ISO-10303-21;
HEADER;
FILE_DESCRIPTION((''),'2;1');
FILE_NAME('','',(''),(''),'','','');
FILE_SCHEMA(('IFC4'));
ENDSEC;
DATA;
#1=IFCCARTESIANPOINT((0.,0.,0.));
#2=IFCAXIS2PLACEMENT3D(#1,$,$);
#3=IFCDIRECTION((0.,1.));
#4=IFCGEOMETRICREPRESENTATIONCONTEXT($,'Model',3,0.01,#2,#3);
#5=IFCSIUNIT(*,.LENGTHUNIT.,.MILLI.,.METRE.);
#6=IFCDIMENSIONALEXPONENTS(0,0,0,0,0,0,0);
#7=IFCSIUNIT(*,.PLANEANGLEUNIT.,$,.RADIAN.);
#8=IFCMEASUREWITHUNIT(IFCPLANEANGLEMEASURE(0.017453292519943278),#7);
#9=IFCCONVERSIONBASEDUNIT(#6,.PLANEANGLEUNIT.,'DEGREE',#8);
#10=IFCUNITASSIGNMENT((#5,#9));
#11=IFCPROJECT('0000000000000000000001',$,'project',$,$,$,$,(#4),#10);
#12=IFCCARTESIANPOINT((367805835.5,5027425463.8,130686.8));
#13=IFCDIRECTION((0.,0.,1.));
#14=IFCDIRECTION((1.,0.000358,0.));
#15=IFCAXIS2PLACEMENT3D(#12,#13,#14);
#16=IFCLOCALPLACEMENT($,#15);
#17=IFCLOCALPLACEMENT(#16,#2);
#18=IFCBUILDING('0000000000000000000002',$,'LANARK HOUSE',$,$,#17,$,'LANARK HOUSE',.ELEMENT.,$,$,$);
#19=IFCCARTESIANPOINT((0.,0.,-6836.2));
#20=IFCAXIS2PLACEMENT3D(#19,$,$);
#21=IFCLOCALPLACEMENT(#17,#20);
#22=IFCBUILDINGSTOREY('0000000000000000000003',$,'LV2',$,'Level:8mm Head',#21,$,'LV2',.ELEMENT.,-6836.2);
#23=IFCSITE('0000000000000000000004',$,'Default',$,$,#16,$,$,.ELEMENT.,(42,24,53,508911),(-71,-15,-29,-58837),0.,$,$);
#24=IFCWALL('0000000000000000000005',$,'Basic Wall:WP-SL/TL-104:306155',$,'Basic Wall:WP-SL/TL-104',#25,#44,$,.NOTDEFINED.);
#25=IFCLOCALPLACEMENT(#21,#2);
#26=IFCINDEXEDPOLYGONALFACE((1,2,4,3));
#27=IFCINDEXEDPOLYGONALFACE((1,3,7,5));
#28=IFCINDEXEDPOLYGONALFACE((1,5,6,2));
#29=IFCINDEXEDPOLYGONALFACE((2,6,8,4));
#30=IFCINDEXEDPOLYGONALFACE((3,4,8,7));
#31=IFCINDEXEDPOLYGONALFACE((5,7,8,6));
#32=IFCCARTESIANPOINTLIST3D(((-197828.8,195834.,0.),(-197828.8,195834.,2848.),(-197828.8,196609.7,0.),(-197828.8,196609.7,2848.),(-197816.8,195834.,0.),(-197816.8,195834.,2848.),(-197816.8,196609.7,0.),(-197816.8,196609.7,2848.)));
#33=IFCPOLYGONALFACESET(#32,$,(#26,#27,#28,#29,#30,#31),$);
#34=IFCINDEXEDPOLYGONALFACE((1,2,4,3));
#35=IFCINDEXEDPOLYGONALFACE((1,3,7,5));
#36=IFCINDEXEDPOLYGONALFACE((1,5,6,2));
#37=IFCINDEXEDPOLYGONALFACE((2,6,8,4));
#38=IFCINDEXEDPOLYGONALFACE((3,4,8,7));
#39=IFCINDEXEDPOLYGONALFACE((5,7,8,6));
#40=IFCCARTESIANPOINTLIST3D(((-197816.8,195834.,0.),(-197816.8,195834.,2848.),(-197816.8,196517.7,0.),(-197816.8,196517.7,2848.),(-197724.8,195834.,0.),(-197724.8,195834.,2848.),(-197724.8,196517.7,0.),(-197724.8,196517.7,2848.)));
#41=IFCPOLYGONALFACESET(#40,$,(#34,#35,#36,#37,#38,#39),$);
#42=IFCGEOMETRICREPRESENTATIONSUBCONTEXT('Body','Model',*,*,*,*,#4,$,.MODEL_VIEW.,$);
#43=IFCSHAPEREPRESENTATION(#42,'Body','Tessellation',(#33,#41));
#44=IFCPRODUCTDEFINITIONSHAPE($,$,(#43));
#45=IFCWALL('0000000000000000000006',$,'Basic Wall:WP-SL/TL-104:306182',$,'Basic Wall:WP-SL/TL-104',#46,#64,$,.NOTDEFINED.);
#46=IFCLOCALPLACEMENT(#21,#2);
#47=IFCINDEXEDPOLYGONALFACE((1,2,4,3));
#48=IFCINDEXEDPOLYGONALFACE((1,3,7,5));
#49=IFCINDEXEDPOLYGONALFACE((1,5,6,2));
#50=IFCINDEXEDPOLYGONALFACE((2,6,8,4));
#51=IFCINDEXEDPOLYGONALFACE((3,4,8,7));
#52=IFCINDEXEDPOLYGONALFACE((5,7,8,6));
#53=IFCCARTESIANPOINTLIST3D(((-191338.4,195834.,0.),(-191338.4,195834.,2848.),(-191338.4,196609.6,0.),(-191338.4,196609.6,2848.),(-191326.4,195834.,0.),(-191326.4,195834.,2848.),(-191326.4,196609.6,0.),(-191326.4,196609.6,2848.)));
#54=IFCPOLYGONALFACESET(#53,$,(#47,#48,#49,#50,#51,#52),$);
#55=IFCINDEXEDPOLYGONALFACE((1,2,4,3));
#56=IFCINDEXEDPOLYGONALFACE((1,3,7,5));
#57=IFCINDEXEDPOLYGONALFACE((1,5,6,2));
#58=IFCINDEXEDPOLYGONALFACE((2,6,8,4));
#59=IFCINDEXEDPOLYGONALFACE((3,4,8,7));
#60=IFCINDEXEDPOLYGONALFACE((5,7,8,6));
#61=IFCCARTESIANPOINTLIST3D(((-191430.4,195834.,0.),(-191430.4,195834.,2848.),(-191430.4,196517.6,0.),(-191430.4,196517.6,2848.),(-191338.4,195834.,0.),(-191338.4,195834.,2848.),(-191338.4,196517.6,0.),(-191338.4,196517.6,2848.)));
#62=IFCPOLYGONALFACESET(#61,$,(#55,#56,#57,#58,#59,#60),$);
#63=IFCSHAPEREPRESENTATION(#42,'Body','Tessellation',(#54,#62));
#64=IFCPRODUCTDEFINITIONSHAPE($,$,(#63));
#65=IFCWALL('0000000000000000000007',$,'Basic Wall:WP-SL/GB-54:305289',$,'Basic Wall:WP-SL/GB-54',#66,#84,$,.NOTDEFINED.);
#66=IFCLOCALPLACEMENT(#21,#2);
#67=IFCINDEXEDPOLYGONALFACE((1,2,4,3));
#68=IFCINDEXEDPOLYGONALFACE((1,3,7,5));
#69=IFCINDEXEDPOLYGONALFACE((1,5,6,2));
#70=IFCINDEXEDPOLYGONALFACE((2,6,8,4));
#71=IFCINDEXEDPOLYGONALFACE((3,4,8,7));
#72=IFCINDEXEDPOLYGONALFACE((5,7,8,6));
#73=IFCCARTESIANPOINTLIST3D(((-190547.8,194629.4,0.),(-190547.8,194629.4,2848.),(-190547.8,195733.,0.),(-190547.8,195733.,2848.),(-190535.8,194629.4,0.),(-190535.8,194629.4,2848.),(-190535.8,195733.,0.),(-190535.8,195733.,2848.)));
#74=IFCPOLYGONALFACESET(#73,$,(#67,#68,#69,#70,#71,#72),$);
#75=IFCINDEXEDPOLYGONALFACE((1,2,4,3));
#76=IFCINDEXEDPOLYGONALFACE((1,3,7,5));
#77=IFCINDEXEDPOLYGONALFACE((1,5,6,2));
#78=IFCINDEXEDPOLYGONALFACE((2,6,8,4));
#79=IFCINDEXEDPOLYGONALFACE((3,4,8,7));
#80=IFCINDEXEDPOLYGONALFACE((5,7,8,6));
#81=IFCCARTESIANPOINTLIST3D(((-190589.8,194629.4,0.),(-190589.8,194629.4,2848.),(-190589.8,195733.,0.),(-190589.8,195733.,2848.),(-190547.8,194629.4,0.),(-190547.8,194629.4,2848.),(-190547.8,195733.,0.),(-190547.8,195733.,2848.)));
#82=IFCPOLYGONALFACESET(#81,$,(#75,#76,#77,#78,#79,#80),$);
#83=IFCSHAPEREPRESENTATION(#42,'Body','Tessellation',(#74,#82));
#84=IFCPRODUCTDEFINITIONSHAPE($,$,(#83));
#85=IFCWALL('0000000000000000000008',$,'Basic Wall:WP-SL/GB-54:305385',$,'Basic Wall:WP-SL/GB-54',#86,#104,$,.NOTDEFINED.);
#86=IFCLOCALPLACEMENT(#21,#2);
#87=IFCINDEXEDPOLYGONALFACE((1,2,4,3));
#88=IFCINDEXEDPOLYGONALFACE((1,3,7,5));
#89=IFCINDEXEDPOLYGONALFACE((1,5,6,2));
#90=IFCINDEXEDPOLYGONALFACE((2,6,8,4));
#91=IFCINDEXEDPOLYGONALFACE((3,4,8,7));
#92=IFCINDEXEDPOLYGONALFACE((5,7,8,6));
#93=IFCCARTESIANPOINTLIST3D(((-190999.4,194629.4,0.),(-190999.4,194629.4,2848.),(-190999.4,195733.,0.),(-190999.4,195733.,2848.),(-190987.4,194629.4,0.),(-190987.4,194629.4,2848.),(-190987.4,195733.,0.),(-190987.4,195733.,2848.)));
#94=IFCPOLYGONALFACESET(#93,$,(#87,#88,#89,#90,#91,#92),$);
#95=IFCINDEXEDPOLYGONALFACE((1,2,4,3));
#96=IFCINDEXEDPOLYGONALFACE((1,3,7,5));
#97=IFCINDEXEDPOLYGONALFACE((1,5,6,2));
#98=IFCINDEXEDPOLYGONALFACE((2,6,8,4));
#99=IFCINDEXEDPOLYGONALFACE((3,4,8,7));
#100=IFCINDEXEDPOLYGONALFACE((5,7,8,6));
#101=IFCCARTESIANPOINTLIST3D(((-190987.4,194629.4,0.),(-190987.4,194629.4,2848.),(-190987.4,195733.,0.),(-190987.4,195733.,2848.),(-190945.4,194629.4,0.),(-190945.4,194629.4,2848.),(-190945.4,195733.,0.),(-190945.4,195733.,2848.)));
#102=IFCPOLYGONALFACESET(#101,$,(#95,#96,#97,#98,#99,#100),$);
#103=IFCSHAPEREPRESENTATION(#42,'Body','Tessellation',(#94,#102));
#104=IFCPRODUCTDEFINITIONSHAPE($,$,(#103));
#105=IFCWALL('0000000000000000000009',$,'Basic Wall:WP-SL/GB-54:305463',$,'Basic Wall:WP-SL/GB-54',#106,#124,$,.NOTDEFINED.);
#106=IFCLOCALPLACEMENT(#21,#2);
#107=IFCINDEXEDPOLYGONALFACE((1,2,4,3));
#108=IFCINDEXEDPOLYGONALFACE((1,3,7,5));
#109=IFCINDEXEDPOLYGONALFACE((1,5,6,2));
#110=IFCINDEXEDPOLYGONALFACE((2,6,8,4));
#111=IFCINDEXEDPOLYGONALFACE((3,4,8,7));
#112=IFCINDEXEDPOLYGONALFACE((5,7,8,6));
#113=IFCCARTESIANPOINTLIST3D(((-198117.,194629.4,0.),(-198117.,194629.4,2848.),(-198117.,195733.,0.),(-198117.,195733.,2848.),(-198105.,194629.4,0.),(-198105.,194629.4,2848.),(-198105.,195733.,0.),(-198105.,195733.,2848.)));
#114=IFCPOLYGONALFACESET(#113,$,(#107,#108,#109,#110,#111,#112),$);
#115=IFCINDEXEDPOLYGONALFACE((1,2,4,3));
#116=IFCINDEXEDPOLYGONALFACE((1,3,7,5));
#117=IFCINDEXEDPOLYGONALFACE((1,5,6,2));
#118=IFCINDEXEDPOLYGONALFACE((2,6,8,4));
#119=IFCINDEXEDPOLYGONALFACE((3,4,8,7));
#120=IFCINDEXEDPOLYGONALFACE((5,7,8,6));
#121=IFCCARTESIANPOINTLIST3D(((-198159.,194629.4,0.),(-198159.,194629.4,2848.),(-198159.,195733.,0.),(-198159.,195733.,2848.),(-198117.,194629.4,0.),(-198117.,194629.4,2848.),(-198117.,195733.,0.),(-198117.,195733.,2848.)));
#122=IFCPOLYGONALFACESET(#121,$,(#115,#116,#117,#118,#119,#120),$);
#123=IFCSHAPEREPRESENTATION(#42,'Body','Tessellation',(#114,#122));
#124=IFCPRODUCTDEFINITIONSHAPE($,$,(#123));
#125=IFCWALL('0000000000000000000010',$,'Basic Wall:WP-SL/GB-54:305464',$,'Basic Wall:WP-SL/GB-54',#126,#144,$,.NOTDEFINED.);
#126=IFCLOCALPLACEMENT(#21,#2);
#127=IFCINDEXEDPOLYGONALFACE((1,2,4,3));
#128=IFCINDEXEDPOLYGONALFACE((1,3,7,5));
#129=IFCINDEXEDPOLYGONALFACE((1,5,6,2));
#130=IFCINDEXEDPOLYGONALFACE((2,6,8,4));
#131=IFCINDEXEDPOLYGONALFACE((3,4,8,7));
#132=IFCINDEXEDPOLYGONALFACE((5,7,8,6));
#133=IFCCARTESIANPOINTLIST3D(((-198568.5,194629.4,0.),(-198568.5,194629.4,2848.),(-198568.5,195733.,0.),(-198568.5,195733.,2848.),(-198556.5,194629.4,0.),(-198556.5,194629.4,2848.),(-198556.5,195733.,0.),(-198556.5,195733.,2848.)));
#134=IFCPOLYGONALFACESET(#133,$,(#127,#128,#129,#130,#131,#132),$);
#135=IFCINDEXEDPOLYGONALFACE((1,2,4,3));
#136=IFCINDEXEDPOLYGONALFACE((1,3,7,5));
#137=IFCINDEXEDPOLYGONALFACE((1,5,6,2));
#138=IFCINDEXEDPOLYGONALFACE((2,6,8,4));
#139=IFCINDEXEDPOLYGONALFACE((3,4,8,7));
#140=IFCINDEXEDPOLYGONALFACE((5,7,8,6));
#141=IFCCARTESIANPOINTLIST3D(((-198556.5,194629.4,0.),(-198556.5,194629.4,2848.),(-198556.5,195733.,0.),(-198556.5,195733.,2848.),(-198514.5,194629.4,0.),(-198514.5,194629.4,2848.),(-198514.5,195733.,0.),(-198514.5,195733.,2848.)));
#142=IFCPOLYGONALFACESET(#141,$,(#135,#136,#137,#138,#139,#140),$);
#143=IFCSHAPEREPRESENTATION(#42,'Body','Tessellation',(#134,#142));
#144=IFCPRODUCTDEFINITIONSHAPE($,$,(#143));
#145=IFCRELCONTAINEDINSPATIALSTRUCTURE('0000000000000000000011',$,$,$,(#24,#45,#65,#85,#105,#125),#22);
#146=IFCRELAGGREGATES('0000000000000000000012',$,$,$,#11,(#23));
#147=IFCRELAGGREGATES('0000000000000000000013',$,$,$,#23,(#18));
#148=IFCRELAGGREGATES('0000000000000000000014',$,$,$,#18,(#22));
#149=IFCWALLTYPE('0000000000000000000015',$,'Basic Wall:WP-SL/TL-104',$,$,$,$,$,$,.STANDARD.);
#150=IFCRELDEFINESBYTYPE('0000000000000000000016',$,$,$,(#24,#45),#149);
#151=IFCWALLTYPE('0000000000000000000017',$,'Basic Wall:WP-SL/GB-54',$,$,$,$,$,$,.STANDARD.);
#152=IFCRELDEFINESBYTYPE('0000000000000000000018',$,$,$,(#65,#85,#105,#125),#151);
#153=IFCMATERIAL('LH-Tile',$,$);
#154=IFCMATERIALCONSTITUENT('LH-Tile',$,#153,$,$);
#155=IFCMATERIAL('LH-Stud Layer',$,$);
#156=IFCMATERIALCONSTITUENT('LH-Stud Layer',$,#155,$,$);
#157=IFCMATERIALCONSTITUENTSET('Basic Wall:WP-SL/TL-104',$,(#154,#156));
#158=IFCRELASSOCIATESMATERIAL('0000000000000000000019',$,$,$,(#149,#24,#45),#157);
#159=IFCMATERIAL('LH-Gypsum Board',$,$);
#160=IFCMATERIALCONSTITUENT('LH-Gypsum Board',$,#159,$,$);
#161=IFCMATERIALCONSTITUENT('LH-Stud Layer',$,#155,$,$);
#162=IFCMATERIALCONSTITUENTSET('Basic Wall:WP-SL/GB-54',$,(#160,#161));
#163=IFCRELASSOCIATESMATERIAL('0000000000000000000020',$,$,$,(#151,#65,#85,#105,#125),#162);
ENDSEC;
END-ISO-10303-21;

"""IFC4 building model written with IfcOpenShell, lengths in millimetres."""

from ifc_helpers import new_model, entity, si_unit, converted_unit, direction, frame, origin, place, context, subcontext, project, spatial, indexed_curve, outline, extrude, material, constituent, constituent_set, type_object, element, save


model = new_model("IFC4")

# Units and contexts
model_context = context("Model", 3, precision=0.01, world=origin(), true_north=direction((0.0, 1.0)))
body_context = subcontext(model_context, "Body", "Model", "MODEL_VIEW")
ifc_project = project(units=[si_unit("LENGTHUNIT", "METRE", prefix="MILLI"), converted_unit("PLANEANGLEUNIT", "DEGREE", entity("IfcPlaneAngleMeasure", 0.017453292519943278), si_unit("PLANEANGLEUNIT", "RADIAN"), dimensions=[0, 0, 0, 0, 0, 0, 0])], contexts=[model_context])

# Site, building, storey
site_placement = place(None, frame((367805835.5, 5027425463.8, 130686.8), z_axis=(0.0, 0.0, 1.0), x_axis=(1.0, 0.000358, 0.0)))
site = spatial("IfcSite", under=ifc_project, at=site_placement, Name="Default", CompositionType="ELEMENT", RefLatitude=(42, 24, 53, 508911), RefLongitude=(-71, -15, -29, -58837), RefElevation=0.0)
building_placement = place(site_placement, origin())
building = spatial("IfcBuilding", under=site, at=building_placement, Name="LANARK HOUSE", LongName="LANARK HOUSE", CompositionType="ELEMENT")
storey_placement = place(building_placement, frame((0.0, 0.0, -6836.2)))
storey = spatial("IfcBuildingStorey", under=building, at=storey_placement, Name="LV2", ObjectType="Level:8mm Head", LongName="LV2", CompositionType="ELEMENT", Elevation=-6836.2)

# Walls
ifc_material_1 = material(Name="LH-Tile")
ifc_constituent_1 = constituent(ifc_material_1, Name="LH-Tile")
ifc_material_2 = material(Name="LH-Stud Layer")
ifc_constituent_2 = constituent(ifc_material_2, Name="LH-Stud Layer")
ifc_constituent_set_1 = constituent_set(constituents=[ifc_constituent_1, ifc_constituent_2], Name="Basic Wall:WP-SL/TL-104")
wall_type_1 = type_object("IfcWallType", Name="Basic Wall:WP-SL/TL-104", PredefinedType="STANDARD", material=ifc_constituent_set_1)
wall_1_placement = place(storey_placement, frame((-197776.8, 195834.0, 0.0), z_axis=(0.0, 0.0, 1.0), x_axis=(0.0, 1.0, 0.0)))
element("IfcWall", 1, at=wall_1_placement, inside=storey, type_object=wall_type_1, material=ifc_constituent_set_1, Name="Basic Wall:WP-SL/TL-104:306155", ObjectType="Basic Wall:WP-SL/TL-104", PredefinedType="NOTDEFINED", context=body_context, shape_type="SweptSolid", body=[
    extrude(outline(indexed_curve([(-6.0, -387.8), (6.0, -387.8), (6.0, 387.8), (-6.0, 387.8), (-6.0, -387.8)], self_intersect=False)), frame((387.8, 46.0, 0.0), z_axis=(0.0, 0.0, 1.0), x_axis=(0.0, -1.0, 0.0)), (0.0, 0.0, 1.0), 2848.0),
    extrude(outline(indexed_curve([(-46.0, -341.8), (46.0, -341.8), (46.0, 341.8), (-46.0, 341.8), (-46.0, -341.8)], self_intersect=False)), frame((341.8, -6.0, 0.0), z_axis=(0.0, 0.0, 1.0), x_axis=(0.0, 1.0, 0.0)), (0.0, 0.0, 1.0), 2848.0),
])
wall_2_placement = place(storey_placement, frame((-191378.4, 196517.6, 0.0), z_axis=(0.0, 0.0, 1.0), x_axis=(0.0, -1.0, 0.0)))
element("IfcWall", 2, at=wall_2_placement, inside=storey, type_object=wall_type_1, material=ifc_constituent_set_1, Name="Basic Wall:WP-SL/TL-104:306182", ObjectType="Basic Wall:WP-SL/TL-104", PredefinedType="NOTDEFINED", context=body_context, shape_type="SweptSolid", body=[
    extrude(outline(indexed_curve([(-6.0, -387.8), (6.0, -387.8), (6.0, 387.8), (-6.0, 387.8), (-6.0, -387.8)], self_intersect=False)), frame((295.8, 46.0, 0.0), z_axis=(0.0, 0.0, 1.0), x_axis=(0.0, -1.0, 0.0)), (0.0, 0.0, 1.0), 2848.0),
    extrude(outline(indexed_curve([(-46.0, -341.8), (46.0, -341.8), (46.0, 341.8), (-46.0, 341.8), (-46.0, -341.8)], self_intersect=False)), frame((341.8, -6.0, 0.0), z_axis=(0.0, 0.0, 1.0), x_axis=(0.0, 1.0, 0.0)), (0.0, 0.0, 1.0), 2848.0),
])
ifc_material_3 = material(Name="LH-Gypsum Board")
ifc_constituent_3 = constituent(ifc_material_3, Name="LH-Gypsum Board")
ifc_constituent_4 = constituent(ifc_material_2, Name="LH-Stud Layer")
ifc_constituent_set_2 = constituent_set(constituents=[ifc_constituent_3, ifc_constituent_4], Name="Basic Wall:WP-SL/GB-54")
wall_type_2 = type_object("IfcWallType", Name="Basic Wall:WP-SL/GB-54", PredefinedType="STANDARD", material=ifc_constituent_set_2)
wall_3_placement = place(storey_placement, frame((-190562.8, 195733.0, 0.0), z_axis=(0.0, 0.0, 1.0), x_axis=(0.0, -1.0, 0.0)))
element("IfcWall", 3, at=wall_3_placement, inside=storey, type_object=wall_type_2, material=ifc_constituent_set_2, Name="Basic Wall:WP-SL/GB-54:305289", ObjectType="Basic Wall:WP-SL/GB-54", PredefinedType="NOTDEFINED", context=body_context, shape_type="SweptSolid", body=[
    extrude(outline(indexed_curve([(-6.0, -551.8), (6.0, -551.8), (6.0, 551.8), (-6.0, 551.8), (-6.0, -551.8)], self_intersect=False)), frame((551.8, 21.0, 0.0), z_axis=(0.0, 0.0, 1.0), x_axis=(0.0, -1.0, 0.0)), (0.0, 0.0, 1.0), 2848.0),
    extrude(outline(indexed_curve([(-21.0, -551.8), (21.0, -551.8), (21.0, 551.8), (-21.0, 551.8), (-21.0, -551.8)], self_intersect=False)), frame((551.8, -6.0, 0.0), z_axis=(0.0, 0.0, 1.0), x_axis=(0.0, 1.0, 0.0)), (0.0, 0.0, 1.0), 2848.0),
])
for number, where, z_axis, x_axis, name in (
    (4, (-190972.4, 194629.4, 0.0), (0.0, 0.0, 1.0), (0.0, 1.0, 0.0), "Basic Wall:WP-SL/GB-54:305385"),
    (5, (-198132.0, 195733.0, 0.0), (0.0, 0.0, 1.0), (0.0, -1.0, 0.0), "Basic Wall:WP-SL/GB-54:305463"),
):
    element("IfcWall", number, at=place(storey_placement, frame(where, z_axis=z_axis, x_axis=x_axis)), inside=storey, type_object=wall_type_2, material=ifc_constituent_set_2, Name=name, ObjectType="Basic Wall:WP-SL/GB-54", PredefinedType="NOTDEFINED", context=body_context, shape_type="SweptSolid", body=[
        extrude(outline(indexed_curve([(-6.0, -551.8), (6.0, -551.8), (6.0, 551.8), (-6.0, 551.8), (-6.0, -551.8)], self_intersect=False)), frame((551.8, 21.0, 0.0), z_axis=(0.0, 0.0, 1.0), x_axis=(0.0, -1.0, 0.0)), (0.0, 0.0, 1.0), 2848.0),
        extrude(outline(indexed_curve([(-21.0, -551.8), (21.0, -551.8), (21.0, 551.8), (-21.0, 551.8), (-21.0, -551.8)], self_intersect=False)), frame((551.8, -6.0, 0.0), z_axis=(0.0, 0.0, 1.0), x_axis=(0.0, 1.0, 0.0)), (0.0, 0.0, 1.0), 2848.0),
    ])
wall_4_placement = place(storey_placement, frame((-198541.5, 194629.4, 0.0), z_axis=(0.0, 0.0, 1.0), x_axis=(0.0, 1.0, 0.0)))
element("IfcWall", 6, at=wall_4_placement, inside=storey, type_object=wall_type_2, material=ifc_constituent_set_2, Name="Basic Wall:WP-SL/GB-54:305464", ObjectType="Basic Wall:WP-SL/GB-54", PredefinedType="NOTDEFINED", context=body_context, shape_type="SweptSolid", body=[
    extrude(outline(indexed_curve([(-6.0, -551.8), (6.0, -551.8), (6.0, 551.8), (-6.0, 551.8), (-6.0, -551.8)], self_intersect=False)), frame((551.8, 21.0, 0.0), z_axis=(0.0, 0.0, 1.0), x_axis=(0.0, -1.0, 0.0)), (0.0, 0.0, 1.0), 2848.0),
    extrude(outline(indexed_curve([(-21.0, -551.8), (21.0, -551.8), (21.0, 551.8), (-21.0, 551.8), (-21.0, -551.8)], self_intersect=False)), frame((551.8, -6.0, 0.0), z_axis=(0.0, 0.0, 1.0), x_axis=(0.0, 1.0, 0.0)), (0.0, 0.0, 1.0), 2848.0),
])

save(model, "model.ifc")
